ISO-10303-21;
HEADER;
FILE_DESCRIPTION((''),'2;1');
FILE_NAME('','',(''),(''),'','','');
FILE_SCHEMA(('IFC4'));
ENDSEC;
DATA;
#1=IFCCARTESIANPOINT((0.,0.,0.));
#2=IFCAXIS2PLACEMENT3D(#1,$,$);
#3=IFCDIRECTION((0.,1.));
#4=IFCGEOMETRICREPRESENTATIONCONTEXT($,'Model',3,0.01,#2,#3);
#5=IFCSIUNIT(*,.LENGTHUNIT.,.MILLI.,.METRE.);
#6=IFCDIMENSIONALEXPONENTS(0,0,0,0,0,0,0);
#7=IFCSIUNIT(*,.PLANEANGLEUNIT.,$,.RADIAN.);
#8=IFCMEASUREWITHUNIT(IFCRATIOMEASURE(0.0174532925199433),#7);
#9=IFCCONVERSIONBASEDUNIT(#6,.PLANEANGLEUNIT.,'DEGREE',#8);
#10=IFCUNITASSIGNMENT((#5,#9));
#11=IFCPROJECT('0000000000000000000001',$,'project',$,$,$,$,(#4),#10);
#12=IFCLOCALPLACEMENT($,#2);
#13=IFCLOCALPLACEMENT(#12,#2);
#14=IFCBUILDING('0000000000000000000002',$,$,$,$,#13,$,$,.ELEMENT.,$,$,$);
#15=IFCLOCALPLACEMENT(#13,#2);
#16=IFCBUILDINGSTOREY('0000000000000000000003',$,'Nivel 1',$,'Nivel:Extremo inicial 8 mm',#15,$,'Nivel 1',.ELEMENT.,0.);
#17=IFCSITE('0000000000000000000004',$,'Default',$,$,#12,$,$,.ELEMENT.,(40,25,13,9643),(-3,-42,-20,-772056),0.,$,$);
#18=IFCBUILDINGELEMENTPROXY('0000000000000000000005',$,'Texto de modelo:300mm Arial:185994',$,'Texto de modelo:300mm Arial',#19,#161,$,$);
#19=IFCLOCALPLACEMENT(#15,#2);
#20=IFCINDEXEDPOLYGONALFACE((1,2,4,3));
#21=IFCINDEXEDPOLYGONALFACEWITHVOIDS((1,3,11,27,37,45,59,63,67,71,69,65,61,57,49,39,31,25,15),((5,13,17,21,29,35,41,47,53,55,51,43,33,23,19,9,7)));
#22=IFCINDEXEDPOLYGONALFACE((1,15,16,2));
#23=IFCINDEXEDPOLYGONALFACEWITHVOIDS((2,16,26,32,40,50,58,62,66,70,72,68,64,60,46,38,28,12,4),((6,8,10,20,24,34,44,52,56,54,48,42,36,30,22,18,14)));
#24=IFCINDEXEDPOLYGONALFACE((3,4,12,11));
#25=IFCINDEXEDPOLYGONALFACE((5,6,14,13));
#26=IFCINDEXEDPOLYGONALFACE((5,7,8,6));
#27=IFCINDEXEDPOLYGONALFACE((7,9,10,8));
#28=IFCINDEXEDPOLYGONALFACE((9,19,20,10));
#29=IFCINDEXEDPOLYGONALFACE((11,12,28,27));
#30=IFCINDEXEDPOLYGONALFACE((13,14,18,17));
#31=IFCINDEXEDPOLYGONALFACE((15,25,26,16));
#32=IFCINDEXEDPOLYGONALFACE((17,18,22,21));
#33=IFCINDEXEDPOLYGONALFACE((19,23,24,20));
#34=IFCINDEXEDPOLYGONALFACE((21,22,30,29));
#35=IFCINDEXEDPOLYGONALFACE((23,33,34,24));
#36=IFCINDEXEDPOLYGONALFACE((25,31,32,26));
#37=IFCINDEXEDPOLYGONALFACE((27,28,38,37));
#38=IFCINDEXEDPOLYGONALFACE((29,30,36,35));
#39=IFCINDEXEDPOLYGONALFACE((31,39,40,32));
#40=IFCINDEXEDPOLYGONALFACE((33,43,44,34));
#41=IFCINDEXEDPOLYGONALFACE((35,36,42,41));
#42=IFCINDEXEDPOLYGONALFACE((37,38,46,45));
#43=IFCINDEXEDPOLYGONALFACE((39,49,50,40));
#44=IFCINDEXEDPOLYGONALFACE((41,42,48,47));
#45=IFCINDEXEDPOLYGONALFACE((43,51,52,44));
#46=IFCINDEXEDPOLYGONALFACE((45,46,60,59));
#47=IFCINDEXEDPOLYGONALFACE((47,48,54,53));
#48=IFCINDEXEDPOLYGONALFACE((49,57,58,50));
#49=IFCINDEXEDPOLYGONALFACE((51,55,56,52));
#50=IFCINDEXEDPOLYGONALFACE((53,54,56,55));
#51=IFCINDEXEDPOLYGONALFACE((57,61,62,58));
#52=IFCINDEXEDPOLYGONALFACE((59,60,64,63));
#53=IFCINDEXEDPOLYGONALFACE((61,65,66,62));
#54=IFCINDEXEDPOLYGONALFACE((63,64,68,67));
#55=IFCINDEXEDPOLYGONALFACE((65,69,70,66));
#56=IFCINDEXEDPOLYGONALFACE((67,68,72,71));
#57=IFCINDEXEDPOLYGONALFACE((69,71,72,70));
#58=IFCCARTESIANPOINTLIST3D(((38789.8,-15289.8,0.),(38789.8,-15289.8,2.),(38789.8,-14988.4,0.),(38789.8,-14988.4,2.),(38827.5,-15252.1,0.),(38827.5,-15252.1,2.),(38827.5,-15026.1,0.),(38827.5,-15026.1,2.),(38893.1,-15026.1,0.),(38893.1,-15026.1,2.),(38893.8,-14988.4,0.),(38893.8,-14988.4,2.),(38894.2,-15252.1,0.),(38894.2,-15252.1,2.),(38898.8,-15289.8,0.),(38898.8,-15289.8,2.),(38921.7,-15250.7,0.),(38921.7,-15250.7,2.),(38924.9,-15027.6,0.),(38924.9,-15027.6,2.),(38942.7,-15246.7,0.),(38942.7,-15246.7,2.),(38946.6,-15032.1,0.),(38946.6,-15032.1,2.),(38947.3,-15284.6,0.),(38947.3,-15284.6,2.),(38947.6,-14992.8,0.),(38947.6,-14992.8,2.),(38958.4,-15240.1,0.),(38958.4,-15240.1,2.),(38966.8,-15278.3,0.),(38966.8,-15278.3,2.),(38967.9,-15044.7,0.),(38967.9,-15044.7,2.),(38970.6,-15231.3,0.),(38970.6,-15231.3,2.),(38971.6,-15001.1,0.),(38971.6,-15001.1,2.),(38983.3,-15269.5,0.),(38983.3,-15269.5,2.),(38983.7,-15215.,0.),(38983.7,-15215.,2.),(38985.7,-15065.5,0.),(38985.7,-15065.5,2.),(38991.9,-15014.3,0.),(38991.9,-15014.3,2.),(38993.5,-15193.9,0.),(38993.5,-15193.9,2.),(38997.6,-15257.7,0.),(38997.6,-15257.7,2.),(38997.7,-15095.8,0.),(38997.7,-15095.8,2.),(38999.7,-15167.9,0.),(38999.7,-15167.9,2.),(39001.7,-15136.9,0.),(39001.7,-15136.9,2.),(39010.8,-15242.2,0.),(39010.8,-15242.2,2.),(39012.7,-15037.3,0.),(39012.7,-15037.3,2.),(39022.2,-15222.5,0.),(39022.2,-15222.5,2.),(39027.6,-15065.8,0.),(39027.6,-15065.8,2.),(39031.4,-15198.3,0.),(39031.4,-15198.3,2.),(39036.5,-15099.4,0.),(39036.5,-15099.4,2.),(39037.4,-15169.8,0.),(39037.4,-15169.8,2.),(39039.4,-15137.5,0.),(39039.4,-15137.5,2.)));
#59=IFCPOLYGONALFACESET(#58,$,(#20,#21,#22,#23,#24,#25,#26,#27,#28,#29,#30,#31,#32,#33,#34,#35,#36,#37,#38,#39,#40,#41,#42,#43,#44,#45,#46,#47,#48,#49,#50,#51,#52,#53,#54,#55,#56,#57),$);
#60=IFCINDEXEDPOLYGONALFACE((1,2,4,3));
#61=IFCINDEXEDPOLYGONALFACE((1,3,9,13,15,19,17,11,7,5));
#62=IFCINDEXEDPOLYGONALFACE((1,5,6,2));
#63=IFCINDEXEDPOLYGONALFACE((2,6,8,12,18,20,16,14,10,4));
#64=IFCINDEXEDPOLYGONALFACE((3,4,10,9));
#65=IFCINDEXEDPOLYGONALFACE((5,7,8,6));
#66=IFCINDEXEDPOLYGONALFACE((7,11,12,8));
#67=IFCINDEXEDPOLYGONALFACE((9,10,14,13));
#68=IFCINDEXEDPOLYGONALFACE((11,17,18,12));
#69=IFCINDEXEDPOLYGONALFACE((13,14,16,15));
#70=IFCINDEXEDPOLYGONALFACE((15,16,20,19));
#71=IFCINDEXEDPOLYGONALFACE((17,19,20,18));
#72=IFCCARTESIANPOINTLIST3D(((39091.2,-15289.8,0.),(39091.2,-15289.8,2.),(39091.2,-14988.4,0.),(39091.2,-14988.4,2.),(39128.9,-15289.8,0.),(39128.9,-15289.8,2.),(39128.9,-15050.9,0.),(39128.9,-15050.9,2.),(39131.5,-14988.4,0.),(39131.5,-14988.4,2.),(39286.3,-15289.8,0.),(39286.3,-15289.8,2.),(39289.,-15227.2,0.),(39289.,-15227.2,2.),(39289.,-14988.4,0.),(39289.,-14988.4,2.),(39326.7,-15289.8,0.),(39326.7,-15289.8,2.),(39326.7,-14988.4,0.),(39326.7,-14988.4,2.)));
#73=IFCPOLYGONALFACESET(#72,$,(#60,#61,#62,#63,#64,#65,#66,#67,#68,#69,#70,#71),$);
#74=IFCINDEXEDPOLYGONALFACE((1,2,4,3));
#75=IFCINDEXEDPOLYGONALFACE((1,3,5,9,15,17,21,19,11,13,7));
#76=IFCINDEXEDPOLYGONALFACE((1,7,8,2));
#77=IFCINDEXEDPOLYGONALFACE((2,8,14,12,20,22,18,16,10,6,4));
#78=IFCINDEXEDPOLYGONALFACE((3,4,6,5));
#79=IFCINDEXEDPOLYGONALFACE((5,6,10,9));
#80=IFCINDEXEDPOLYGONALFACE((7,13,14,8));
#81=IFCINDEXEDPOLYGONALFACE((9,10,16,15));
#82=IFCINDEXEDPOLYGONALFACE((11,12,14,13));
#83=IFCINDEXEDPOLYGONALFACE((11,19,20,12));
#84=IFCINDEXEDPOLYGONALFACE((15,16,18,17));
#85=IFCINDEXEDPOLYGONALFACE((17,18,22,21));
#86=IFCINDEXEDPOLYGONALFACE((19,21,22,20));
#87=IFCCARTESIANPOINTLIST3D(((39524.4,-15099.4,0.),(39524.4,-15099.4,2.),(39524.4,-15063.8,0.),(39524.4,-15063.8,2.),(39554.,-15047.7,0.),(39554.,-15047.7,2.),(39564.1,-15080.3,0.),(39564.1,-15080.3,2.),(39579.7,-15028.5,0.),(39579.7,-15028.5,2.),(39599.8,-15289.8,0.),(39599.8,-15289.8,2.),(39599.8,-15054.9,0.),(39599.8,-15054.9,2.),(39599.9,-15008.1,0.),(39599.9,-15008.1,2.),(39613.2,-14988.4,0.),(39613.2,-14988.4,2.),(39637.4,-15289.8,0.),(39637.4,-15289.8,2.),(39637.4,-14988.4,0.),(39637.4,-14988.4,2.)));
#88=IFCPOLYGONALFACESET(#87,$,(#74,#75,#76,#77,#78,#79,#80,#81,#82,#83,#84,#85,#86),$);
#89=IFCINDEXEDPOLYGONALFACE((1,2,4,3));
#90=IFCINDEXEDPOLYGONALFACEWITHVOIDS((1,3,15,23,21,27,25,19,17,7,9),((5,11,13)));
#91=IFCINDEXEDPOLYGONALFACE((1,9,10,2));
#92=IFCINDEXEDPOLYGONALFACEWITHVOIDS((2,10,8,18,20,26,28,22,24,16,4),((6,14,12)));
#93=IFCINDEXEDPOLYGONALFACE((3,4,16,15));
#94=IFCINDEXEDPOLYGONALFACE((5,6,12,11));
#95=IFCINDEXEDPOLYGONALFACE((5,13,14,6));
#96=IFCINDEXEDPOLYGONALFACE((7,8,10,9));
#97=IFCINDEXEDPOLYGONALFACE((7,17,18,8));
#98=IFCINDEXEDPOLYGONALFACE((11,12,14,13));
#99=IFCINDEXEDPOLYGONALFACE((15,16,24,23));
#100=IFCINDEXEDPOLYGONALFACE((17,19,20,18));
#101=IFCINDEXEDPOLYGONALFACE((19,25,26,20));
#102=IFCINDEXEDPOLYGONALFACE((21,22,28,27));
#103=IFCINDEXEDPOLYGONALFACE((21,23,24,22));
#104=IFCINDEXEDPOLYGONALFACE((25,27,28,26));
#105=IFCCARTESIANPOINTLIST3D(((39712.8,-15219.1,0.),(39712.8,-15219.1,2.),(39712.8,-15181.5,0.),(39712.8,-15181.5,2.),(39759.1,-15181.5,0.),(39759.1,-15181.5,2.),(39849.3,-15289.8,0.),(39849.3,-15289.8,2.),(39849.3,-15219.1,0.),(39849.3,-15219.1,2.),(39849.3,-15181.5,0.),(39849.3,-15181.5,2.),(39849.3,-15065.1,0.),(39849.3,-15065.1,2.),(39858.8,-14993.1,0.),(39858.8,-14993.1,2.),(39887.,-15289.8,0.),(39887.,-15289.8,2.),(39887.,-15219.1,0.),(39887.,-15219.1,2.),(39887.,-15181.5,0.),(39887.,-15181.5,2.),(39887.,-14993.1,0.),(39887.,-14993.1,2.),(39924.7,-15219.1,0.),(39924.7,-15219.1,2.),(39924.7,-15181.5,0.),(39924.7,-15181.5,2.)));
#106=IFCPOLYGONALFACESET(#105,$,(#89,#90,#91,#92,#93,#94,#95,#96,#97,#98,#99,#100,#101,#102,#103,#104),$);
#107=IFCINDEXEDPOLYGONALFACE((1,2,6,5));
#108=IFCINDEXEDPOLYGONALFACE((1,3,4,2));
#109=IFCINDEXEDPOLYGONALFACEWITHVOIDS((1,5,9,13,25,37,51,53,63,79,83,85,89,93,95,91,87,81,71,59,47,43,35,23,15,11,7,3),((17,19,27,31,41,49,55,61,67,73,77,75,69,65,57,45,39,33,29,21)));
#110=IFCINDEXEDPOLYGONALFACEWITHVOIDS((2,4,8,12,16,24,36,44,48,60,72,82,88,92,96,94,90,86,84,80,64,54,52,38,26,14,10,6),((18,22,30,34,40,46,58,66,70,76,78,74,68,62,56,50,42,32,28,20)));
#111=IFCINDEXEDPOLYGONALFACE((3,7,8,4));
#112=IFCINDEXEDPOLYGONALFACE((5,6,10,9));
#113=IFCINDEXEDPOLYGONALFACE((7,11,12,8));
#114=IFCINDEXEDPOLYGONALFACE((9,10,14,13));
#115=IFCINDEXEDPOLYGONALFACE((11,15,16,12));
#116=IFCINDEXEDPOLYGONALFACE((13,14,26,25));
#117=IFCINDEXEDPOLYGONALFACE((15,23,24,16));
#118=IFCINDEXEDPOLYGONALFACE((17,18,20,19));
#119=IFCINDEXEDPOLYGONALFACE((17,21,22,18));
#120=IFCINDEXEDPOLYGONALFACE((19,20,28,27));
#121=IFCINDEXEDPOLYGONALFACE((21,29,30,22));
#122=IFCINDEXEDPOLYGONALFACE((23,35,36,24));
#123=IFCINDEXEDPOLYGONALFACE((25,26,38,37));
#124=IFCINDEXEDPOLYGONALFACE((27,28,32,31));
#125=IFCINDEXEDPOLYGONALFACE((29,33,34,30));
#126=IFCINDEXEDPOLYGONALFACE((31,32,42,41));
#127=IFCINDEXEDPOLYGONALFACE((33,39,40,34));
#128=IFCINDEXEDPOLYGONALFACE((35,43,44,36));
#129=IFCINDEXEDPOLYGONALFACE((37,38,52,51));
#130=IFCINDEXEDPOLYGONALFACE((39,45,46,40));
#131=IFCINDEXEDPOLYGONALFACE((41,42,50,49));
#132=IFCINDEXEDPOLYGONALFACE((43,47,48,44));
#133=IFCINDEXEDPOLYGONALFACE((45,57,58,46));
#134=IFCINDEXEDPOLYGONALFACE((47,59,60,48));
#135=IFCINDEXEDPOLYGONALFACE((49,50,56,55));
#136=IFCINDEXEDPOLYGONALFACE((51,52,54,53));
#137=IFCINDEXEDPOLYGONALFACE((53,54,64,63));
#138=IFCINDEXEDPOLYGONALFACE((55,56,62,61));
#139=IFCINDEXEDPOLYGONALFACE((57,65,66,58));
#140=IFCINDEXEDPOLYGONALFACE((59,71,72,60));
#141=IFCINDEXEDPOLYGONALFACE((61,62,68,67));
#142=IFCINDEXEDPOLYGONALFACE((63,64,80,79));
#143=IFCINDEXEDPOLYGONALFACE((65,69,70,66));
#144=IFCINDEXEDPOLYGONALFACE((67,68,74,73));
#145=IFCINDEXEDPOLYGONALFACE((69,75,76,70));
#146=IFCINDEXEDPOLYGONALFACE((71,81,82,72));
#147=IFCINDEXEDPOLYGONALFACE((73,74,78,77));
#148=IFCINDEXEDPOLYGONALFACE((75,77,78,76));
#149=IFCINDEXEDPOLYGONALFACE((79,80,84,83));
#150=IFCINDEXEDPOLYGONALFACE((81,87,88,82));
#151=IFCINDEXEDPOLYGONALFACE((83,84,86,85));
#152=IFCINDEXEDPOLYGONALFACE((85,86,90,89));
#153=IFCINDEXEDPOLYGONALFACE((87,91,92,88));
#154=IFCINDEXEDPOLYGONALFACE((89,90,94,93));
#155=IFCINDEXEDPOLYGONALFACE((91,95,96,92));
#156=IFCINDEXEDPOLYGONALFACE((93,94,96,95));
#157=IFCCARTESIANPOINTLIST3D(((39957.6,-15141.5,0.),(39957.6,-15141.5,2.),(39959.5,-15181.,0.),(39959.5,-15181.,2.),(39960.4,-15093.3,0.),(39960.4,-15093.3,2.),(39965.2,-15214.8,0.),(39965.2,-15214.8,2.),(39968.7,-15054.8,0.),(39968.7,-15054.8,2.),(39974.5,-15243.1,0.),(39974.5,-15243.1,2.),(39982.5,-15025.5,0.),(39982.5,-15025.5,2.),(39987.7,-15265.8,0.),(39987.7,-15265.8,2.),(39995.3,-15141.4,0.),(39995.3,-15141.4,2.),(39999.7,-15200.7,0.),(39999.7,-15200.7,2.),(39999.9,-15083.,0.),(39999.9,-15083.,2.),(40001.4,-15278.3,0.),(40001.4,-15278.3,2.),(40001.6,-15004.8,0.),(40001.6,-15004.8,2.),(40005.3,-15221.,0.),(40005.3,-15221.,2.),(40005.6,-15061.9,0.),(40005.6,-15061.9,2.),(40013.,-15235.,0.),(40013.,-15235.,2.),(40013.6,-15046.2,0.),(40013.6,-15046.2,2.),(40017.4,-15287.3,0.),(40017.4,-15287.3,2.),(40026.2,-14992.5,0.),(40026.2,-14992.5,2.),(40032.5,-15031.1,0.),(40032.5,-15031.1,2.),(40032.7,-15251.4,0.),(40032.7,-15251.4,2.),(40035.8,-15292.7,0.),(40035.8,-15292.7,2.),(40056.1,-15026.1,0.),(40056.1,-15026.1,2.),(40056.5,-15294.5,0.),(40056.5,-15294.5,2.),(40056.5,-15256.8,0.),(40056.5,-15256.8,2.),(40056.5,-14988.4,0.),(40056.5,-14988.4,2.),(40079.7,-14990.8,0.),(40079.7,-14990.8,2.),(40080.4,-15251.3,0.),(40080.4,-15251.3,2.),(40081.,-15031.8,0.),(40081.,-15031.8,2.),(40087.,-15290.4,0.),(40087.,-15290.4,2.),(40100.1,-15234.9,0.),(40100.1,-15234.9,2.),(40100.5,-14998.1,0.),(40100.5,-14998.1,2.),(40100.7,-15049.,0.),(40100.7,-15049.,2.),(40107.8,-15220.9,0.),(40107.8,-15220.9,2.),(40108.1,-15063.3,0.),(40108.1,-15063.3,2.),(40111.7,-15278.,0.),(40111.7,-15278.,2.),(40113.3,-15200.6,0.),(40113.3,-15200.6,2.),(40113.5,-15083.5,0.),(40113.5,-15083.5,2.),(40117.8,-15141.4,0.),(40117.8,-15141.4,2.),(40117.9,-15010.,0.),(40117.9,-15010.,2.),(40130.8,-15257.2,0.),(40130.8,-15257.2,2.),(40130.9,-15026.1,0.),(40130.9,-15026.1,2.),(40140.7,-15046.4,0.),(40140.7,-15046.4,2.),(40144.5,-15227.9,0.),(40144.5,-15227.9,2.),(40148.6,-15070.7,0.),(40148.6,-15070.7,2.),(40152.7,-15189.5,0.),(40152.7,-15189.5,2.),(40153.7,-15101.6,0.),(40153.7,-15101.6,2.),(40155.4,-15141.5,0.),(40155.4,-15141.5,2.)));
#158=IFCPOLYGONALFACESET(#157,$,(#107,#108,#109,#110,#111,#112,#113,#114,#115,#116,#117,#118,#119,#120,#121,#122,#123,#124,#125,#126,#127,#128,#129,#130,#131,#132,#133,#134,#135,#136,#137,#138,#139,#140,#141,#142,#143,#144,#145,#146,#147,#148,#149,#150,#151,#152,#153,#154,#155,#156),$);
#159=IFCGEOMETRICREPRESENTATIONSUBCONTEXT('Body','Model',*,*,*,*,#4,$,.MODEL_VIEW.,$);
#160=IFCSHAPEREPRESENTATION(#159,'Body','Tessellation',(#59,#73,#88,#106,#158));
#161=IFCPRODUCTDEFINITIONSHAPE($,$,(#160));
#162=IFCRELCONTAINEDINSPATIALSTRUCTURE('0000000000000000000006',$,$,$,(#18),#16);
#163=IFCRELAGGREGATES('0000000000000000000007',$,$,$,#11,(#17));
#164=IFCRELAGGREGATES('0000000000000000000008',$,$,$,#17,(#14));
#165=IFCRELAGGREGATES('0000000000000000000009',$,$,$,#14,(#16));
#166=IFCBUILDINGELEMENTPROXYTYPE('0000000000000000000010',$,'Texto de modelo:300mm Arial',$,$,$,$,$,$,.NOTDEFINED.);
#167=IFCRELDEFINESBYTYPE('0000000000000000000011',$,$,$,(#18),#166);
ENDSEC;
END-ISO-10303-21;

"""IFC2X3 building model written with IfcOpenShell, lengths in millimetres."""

from ifc_helpers import new_model, entity, si_unit, converted_unit, direction, frame, origin, place, context, subcontext, project, spatial, polyline, outline, extrude, type_object, element, save


model = new_model("IFC2X3")

# Units and contexts
model_context = context("Model", 3, precision=0.01, world=origin(), true_north=direction((0.0, 1.0)))
body_context = subcontext(model_context, "Body", "Model", "MODEL_VIEW")
ifc_project = project(units=[si_unit("LENGTHUNIT", "METRE", prefix="MILLI"), converted_unit("PLANEANGLEUNIT", "DEGREE", entity("IfcRatioMeasure", 0.0174532925199433), si_unit("PLANEANGLEUNIT", "RADIAN"), dimensions=[0, 0, 0, 0, 0, 0, 0])], contexts=[model_context])

# Site, building, storey
site_placement = place(None, origin())
site = spatial("IfcSite", under=ifc_project, at=site_placement, Name="Default", CompositionType="ELEMENT", RefLatitude=(40, 25, 13, 9643), RefLongitude=(-3, -42, -20, -772056), RefElevation=0.0)
building_placement = place(site_placement, origin())
building = spatial("IfcBuilding", under=site, at=building_placement, CompositionType="ELEMENT")
storey_placement = place(building_placement, origin())
storey = spatial("IfcBuildingStorey", under=building, at=storey_placement, Name="Nivel 1", ObjectType="Nivel:Extremo inicial 8 mm", LongName="Nivel 1", CompositionType="ELEMENT", Elevation=0.0)

# Building element proxy
building_element_proxy_type_1 = type_object("IfcBuildingElementProxyType", Name="Texto de modelo:300mm Arial", PredefinedType="NOTDEFINED")
proxy_1_placement = place(storey_placement, frame((38789.8, -15294.5, 0.0)))
element("IfcBuildingElementProxy", 1, at=proxy_1_placement, inside=storey, type_object=building_element_proxy_type_1, Name="Texto de modelo:300mm Arial:185994", ObjectType="Texto de modelo:300mm Arial", context=body_context, shape_type="SweptSolid", body=[
    extrude(outline(polyline([(-178.4, -141.0), (-69.4, -141.0), (-21.0, -135.8), (-1.4, -129.5), (15.0, -120.7), (29.4, -108.9), (42.6, -93.4), (54.0, -73.7), (63.2, -49.5), (69.2, -21.0), (71.2, 11.3), (68.2, 49.4), (59.3, 83.0), (44.5, 111.5), (23.7, 134.5), (3.4, 147.7), (-20.6, 156.1), (-74.4, 160.4), (-178.4, 160.4), (-178.4, -141.0)]), holes=[polyline([(-140.7, -103.3), (-140.7, 122.7), (-75.1, 122.7), (-43.3, 121.2), (-21.7, 116.7), (-0.4, 104.1), (17.4, 83.3), (29.5, 53.0), (33.5, 11.9), (31.5, -19.1), (25.3, -45.1), (15.5, -66.2), (2.4, -82.5), (-9.8, -91.3), (-25.6, -97.9), (-46.5, -101.9), (-74.1, -103.3), (-140.7, -103.3)])]), frame((178.4, 145.7, 0.0)), (0.0, 0.0, 1.0), 2.0),
    extrude(outline(polyline([(-117.7, -150.7), (-80.1, -150.7), (-80.1, 88.1), (77.4, -150.7), (117.7, -150.7), (117.7, 150.7), (80.1, 150.7), (80.1, -88.1), (-77.4, 150.7), (-117.7, 150.7), (-117.7, -150.7)])), frame((419.1, 155.4, 0.0)), (0.0, 0.0, 1.0), 2.0),
    extrude(outline(polyline([(-204.4, -52.5), (97.0, -52.5), (97.0, -28.2), (77.2, -14.9), (56.9, 5.3), (37.7, 30.9), (21.6, 60.5), (-14.0, 60.5), (5.0, 20.8), (30.4, -14.9), (-204.4, -14.9), (-204.4, -52.5)])), frame((795.1, 209.1, 0.0), z_axis=(0.0, 0.0, 1.0), x_axis=(0.0, 1.0, 0.0)), (0.0, 0.0, 1.0), 2.0),
    extrude(outline(polyline([(-3.4, -109.2), (34.2, -109.2), (34.2, -38.5), (71.9, -38.5), (71.9, -0.9), (34.2, -0.9), (34.2, 187.5), (6.0, 187.5), (-140.0, -0.9), (-140.0, -38.5), (-3.4, -38.5), (-3.4, -109.2)]), holes=[polyline([(-3.4, -0.9), (-93.6, -0.9), (-3.4, 115.5), (-3.4, -0.9)])]), frame((1062.9, 113.9, 0.0)), (0.0, 0.0, 1.0), 2.0),
    extrude(outline(polyline([(-5.6, -99.5), (33.9, -99.5), (68.0, -95.5), (96.7, -87.5), (120.0, -75.5), (133.2, -62.4), (142.9, -46.8), (149.1, -28.7), (151.9, -8.0), (149.2, 22.6), (138.0, 47.8), (118.2, 67.9), (89.5, 82.9), (51.6, 93.0), (3.8, 98.0), (-36.2, 98.2), (-67.3, 94.5), (-91.9, 87.9), (-112.6, 79.0), (-129.4, 66.8), (-142.0, 50.0), (-150.3, 29.6), (-153.8, 6.5), (-151.2, -23.9), (-140.1, -49.1), (-120.3, -69.2), (-91.7, -84.4), (-53.6, -94.5), (-5.6, -99.5)]), holes=[polyline([(-3.9, -61.9), (-62.1, -54.6), (-82.9, -47.9), (-98.1, -39.2), (-112.3, -19.5), (-116.2, 4.3), (-109.3, 28.9), (-91.2, 47.7), (-76.5, 54.5), (-56.1, 58.9), (1.9, 60.4), (60.8, 53.2), (80.8, 46.7), (94.5, 38.3), (109.9, 17.8), (114.3, -6.3), (107.7, -29.8), (90.4, -48.7), (76.0, -55.8), (55.5, -60.3), (-3.9, -61.9)])]), frame((1267.5, 152.1, 0.0), z_axis=(0.0, 0.0, 1.0), x_axis=(0.047515, -0.998871, 0.0)), (0.0, 0.0, 1.0), 2.0),
])

save(model, "model.ifc")
